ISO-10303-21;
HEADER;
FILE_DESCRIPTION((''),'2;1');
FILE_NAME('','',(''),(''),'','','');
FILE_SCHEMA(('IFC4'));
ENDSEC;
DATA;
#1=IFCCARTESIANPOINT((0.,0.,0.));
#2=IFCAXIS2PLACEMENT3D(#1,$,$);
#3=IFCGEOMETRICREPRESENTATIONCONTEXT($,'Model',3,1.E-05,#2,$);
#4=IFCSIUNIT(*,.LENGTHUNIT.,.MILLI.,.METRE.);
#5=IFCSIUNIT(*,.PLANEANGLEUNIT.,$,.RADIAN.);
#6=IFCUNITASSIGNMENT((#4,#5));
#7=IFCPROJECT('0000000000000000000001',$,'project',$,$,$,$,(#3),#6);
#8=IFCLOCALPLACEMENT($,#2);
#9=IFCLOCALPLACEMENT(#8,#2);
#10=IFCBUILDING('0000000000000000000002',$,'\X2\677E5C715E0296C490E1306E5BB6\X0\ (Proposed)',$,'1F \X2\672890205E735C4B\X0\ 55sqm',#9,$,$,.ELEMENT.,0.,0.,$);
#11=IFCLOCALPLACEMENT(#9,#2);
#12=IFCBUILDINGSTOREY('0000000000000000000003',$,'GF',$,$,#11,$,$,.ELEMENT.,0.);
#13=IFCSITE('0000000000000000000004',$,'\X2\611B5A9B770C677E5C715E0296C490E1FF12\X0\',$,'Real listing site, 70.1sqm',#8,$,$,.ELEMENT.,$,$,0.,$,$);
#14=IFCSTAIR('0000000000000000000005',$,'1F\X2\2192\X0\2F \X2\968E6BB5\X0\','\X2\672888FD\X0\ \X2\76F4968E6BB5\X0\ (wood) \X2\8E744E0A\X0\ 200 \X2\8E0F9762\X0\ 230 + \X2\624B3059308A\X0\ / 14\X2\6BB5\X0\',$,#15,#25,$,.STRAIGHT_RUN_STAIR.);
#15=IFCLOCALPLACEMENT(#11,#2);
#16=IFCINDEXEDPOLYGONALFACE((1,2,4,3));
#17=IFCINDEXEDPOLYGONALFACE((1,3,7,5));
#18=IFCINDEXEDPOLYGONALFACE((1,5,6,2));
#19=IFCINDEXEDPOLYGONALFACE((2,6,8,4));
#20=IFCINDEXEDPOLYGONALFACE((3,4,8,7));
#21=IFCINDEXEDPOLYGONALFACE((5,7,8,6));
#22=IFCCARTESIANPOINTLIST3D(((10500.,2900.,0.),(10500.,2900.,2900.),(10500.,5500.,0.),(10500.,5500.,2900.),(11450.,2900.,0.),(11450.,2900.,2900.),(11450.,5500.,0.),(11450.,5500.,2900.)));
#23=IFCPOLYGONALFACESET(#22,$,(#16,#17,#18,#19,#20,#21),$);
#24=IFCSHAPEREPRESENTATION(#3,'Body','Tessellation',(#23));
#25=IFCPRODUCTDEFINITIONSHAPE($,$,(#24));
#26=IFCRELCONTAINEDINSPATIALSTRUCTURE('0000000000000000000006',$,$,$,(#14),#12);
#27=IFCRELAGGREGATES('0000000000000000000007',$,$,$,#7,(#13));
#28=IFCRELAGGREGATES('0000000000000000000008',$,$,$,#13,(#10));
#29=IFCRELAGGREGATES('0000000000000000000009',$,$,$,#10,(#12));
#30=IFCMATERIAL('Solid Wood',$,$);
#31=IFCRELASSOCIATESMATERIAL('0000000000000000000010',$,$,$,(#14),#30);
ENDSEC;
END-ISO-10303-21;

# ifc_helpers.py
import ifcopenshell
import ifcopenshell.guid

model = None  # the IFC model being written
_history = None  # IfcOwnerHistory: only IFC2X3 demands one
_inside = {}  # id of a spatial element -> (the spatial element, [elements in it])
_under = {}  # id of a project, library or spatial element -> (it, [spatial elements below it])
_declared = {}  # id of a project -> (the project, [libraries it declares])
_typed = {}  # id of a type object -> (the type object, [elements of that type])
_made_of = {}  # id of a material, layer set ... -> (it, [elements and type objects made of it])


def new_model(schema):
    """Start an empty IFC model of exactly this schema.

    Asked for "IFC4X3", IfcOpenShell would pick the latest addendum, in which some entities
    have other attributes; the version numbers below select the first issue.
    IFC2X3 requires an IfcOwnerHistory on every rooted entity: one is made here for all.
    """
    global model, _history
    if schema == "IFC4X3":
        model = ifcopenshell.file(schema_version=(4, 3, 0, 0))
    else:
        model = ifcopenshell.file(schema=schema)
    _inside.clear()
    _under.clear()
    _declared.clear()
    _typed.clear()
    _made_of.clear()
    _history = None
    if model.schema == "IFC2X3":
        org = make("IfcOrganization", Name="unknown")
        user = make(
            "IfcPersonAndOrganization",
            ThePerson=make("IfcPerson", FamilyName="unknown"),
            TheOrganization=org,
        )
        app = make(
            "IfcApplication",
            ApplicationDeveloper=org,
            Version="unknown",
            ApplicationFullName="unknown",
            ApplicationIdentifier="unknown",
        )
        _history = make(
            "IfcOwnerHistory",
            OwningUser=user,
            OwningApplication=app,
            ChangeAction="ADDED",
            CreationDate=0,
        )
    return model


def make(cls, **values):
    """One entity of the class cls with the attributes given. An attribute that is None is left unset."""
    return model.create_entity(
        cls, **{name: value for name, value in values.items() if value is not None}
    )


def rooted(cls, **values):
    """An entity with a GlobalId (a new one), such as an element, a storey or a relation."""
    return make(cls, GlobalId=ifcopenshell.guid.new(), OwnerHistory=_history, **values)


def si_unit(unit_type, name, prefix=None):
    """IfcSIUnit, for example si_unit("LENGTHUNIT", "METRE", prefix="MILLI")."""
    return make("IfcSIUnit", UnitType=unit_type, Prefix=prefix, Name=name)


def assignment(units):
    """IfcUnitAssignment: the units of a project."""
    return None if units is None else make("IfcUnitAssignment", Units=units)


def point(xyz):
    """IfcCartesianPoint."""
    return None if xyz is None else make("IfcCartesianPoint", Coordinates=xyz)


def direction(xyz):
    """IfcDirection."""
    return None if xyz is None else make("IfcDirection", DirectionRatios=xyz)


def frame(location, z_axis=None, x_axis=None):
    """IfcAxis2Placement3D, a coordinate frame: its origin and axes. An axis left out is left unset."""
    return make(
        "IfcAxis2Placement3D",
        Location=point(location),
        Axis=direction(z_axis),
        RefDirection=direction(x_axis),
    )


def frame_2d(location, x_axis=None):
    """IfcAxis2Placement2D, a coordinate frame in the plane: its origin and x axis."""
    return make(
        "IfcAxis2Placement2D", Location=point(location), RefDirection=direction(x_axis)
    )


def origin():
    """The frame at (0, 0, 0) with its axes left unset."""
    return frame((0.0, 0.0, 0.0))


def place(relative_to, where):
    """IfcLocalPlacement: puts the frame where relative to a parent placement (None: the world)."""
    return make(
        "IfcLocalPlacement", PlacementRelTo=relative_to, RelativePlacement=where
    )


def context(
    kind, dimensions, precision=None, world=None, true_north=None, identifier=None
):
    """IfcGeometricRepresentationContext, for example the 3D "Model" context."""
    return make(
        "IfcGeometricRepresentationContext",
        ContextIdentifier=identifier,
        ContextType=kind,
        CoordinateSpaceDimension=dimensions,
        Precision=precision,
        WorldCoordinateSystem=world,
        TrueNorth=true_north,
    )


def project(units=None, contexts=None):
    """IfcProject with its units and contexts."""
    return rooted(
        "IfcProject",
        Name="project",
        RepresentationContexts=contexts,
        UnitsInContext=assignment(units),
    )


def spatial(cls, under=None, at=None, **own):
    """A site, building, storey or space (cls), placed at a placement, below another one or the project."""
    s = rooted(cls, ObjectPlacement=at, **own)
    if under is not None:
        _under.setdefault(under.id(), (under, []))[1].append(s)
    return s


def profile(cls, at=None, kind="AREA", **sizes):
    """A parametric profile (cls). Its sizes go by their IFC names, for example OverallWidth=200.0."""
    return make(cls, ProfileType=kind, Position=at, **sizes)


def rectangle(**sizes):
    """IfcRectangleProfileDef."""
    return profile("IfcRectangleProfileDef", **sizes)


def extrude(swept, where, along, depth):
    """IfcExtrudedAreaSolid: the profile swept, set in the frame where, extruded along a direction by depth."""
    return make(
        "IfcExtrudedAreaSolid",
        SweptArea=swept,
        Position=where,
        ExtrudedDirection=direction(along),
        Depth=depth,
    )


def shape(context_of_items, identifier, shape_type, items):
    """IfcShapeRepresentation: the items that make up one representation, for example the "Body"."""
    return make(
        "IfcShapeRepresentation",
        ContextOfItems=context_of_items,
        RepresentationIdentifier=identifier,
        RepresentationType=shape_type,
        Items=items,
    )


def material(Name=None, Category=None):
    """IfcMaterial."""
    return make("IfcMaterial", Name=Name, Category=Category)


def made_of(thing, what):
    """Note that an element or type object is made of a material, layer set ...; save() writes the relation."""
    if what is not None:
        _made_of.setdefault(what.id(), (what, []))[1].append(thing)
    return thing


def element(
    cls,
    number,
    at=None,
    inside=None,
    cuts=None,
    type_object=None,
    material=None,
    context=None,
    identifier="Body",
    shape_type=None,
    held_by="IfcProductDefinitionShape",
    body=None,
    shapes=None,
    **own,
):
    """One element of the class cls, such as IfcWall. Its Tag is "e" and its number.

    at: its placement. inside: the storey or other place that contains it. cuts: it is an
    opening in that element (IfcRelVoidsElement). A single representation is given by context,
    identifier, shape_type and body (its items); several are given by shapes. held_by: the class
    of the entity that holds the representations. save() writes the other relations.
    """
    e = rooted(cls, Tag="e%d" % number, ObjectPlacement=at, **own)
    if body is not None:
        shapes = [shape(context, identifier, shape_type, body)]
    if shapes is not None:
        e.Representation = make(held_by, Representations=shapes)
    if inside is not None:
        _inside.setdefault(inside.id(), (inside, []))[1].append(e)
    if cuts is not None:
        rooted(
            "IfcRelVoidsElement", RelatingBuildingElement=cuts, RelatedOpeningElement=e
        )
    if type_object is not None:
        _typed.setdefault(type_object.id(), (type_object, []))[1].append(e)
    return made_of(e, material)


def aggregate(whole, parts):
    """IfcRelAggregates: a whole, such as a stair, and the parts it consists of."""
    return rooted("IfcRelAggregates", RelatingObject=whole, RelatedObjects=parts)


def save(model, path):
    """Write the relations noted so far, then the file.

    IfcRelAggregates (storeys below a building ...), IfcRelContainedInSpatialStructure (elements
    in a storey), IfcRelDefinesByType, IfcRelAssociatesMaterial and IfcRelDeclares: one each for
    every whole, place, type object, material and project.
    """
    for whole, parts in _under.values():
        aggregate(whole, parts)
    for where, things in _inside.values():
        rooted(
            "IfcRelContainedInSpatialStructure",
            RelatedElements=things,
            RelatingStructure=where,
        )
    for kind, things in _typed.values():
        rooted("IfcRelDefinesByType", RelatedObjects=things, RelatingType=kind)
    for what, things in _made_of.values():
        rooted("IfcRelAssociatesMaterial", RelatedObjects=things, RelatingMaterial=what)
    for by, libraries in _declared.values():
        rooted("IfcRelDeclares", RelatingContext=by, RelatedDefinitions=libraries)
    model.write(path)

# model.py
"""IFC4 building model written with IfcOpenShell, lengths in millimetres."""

from ifc_helpers import new_model, si_unit, frame, frame_2d, origin, place, context, project, spatial, rectangle, extrude, material, element, save


model = new_model("IFC4")

# Units and contexts
model_context = context("Model", 3, precision=1e-05, world=origin())
ifc_project = project(units=[si_unit("LENGTHUNIT", "METRE", prefix="MILLI"), si_unit("PLANEANGLEUNIT", "RADIAN")], contexts=[model_context])

# Site, building, storey
site_placement = place(None, origin())
site = spatial("IfcSite", under=ifc_project, at=site_placement, Name="愛媛県松山市雄郡２", ObjectType="Real listing site, 70.1sqm", CompositionType="ELEMENT", RefElevation=0.0)
building_placement = place(site_placement, origin())
building = spatial("IfcBuilding", under=site, at=building_placement, Name="松山市雄郡の家 (Proposed)", ObjectType="1F 木造平屋 55sqm", CompositionType="ELEMENT", ElevationOfRefHeight=0.0, ElevationOfTerrain=0.0)
storey_placement = place(building_placement, origin())
storey = spatial("IfcBuildingStorey", under=building, at=storey_placement, Name="GF", CompositionType="ELEMENT", Elevation=0.0)

# Shared definitions
ifc_material_1 = material(Name="Solid Wood")

# Stair
stair_placement = place(storey_placement, frame((5250.0, 1450.0, 0.0)))
element("IfcStair", 1, at=stair_placement, inside=storey, material=ifc_material_1, Name="1F→2F 階段", Description="木製 直階段 (wood) 蹴上 200 踏面 230 + 手すり / 14段", PredefinedType="STRAIGHT_RUN_STAIR", context=model_context, shape_type="SweptSolid", body=[
    extrude(rectangle(XDim=950.0, YDim=2600.0, at=frame_2d((475.0, 1300.0))), frame((5250.0, 1450.0, 0.0)), (0.0, 0.0, 1.0), 2900.0),
])

save(model, "model.ifc")
